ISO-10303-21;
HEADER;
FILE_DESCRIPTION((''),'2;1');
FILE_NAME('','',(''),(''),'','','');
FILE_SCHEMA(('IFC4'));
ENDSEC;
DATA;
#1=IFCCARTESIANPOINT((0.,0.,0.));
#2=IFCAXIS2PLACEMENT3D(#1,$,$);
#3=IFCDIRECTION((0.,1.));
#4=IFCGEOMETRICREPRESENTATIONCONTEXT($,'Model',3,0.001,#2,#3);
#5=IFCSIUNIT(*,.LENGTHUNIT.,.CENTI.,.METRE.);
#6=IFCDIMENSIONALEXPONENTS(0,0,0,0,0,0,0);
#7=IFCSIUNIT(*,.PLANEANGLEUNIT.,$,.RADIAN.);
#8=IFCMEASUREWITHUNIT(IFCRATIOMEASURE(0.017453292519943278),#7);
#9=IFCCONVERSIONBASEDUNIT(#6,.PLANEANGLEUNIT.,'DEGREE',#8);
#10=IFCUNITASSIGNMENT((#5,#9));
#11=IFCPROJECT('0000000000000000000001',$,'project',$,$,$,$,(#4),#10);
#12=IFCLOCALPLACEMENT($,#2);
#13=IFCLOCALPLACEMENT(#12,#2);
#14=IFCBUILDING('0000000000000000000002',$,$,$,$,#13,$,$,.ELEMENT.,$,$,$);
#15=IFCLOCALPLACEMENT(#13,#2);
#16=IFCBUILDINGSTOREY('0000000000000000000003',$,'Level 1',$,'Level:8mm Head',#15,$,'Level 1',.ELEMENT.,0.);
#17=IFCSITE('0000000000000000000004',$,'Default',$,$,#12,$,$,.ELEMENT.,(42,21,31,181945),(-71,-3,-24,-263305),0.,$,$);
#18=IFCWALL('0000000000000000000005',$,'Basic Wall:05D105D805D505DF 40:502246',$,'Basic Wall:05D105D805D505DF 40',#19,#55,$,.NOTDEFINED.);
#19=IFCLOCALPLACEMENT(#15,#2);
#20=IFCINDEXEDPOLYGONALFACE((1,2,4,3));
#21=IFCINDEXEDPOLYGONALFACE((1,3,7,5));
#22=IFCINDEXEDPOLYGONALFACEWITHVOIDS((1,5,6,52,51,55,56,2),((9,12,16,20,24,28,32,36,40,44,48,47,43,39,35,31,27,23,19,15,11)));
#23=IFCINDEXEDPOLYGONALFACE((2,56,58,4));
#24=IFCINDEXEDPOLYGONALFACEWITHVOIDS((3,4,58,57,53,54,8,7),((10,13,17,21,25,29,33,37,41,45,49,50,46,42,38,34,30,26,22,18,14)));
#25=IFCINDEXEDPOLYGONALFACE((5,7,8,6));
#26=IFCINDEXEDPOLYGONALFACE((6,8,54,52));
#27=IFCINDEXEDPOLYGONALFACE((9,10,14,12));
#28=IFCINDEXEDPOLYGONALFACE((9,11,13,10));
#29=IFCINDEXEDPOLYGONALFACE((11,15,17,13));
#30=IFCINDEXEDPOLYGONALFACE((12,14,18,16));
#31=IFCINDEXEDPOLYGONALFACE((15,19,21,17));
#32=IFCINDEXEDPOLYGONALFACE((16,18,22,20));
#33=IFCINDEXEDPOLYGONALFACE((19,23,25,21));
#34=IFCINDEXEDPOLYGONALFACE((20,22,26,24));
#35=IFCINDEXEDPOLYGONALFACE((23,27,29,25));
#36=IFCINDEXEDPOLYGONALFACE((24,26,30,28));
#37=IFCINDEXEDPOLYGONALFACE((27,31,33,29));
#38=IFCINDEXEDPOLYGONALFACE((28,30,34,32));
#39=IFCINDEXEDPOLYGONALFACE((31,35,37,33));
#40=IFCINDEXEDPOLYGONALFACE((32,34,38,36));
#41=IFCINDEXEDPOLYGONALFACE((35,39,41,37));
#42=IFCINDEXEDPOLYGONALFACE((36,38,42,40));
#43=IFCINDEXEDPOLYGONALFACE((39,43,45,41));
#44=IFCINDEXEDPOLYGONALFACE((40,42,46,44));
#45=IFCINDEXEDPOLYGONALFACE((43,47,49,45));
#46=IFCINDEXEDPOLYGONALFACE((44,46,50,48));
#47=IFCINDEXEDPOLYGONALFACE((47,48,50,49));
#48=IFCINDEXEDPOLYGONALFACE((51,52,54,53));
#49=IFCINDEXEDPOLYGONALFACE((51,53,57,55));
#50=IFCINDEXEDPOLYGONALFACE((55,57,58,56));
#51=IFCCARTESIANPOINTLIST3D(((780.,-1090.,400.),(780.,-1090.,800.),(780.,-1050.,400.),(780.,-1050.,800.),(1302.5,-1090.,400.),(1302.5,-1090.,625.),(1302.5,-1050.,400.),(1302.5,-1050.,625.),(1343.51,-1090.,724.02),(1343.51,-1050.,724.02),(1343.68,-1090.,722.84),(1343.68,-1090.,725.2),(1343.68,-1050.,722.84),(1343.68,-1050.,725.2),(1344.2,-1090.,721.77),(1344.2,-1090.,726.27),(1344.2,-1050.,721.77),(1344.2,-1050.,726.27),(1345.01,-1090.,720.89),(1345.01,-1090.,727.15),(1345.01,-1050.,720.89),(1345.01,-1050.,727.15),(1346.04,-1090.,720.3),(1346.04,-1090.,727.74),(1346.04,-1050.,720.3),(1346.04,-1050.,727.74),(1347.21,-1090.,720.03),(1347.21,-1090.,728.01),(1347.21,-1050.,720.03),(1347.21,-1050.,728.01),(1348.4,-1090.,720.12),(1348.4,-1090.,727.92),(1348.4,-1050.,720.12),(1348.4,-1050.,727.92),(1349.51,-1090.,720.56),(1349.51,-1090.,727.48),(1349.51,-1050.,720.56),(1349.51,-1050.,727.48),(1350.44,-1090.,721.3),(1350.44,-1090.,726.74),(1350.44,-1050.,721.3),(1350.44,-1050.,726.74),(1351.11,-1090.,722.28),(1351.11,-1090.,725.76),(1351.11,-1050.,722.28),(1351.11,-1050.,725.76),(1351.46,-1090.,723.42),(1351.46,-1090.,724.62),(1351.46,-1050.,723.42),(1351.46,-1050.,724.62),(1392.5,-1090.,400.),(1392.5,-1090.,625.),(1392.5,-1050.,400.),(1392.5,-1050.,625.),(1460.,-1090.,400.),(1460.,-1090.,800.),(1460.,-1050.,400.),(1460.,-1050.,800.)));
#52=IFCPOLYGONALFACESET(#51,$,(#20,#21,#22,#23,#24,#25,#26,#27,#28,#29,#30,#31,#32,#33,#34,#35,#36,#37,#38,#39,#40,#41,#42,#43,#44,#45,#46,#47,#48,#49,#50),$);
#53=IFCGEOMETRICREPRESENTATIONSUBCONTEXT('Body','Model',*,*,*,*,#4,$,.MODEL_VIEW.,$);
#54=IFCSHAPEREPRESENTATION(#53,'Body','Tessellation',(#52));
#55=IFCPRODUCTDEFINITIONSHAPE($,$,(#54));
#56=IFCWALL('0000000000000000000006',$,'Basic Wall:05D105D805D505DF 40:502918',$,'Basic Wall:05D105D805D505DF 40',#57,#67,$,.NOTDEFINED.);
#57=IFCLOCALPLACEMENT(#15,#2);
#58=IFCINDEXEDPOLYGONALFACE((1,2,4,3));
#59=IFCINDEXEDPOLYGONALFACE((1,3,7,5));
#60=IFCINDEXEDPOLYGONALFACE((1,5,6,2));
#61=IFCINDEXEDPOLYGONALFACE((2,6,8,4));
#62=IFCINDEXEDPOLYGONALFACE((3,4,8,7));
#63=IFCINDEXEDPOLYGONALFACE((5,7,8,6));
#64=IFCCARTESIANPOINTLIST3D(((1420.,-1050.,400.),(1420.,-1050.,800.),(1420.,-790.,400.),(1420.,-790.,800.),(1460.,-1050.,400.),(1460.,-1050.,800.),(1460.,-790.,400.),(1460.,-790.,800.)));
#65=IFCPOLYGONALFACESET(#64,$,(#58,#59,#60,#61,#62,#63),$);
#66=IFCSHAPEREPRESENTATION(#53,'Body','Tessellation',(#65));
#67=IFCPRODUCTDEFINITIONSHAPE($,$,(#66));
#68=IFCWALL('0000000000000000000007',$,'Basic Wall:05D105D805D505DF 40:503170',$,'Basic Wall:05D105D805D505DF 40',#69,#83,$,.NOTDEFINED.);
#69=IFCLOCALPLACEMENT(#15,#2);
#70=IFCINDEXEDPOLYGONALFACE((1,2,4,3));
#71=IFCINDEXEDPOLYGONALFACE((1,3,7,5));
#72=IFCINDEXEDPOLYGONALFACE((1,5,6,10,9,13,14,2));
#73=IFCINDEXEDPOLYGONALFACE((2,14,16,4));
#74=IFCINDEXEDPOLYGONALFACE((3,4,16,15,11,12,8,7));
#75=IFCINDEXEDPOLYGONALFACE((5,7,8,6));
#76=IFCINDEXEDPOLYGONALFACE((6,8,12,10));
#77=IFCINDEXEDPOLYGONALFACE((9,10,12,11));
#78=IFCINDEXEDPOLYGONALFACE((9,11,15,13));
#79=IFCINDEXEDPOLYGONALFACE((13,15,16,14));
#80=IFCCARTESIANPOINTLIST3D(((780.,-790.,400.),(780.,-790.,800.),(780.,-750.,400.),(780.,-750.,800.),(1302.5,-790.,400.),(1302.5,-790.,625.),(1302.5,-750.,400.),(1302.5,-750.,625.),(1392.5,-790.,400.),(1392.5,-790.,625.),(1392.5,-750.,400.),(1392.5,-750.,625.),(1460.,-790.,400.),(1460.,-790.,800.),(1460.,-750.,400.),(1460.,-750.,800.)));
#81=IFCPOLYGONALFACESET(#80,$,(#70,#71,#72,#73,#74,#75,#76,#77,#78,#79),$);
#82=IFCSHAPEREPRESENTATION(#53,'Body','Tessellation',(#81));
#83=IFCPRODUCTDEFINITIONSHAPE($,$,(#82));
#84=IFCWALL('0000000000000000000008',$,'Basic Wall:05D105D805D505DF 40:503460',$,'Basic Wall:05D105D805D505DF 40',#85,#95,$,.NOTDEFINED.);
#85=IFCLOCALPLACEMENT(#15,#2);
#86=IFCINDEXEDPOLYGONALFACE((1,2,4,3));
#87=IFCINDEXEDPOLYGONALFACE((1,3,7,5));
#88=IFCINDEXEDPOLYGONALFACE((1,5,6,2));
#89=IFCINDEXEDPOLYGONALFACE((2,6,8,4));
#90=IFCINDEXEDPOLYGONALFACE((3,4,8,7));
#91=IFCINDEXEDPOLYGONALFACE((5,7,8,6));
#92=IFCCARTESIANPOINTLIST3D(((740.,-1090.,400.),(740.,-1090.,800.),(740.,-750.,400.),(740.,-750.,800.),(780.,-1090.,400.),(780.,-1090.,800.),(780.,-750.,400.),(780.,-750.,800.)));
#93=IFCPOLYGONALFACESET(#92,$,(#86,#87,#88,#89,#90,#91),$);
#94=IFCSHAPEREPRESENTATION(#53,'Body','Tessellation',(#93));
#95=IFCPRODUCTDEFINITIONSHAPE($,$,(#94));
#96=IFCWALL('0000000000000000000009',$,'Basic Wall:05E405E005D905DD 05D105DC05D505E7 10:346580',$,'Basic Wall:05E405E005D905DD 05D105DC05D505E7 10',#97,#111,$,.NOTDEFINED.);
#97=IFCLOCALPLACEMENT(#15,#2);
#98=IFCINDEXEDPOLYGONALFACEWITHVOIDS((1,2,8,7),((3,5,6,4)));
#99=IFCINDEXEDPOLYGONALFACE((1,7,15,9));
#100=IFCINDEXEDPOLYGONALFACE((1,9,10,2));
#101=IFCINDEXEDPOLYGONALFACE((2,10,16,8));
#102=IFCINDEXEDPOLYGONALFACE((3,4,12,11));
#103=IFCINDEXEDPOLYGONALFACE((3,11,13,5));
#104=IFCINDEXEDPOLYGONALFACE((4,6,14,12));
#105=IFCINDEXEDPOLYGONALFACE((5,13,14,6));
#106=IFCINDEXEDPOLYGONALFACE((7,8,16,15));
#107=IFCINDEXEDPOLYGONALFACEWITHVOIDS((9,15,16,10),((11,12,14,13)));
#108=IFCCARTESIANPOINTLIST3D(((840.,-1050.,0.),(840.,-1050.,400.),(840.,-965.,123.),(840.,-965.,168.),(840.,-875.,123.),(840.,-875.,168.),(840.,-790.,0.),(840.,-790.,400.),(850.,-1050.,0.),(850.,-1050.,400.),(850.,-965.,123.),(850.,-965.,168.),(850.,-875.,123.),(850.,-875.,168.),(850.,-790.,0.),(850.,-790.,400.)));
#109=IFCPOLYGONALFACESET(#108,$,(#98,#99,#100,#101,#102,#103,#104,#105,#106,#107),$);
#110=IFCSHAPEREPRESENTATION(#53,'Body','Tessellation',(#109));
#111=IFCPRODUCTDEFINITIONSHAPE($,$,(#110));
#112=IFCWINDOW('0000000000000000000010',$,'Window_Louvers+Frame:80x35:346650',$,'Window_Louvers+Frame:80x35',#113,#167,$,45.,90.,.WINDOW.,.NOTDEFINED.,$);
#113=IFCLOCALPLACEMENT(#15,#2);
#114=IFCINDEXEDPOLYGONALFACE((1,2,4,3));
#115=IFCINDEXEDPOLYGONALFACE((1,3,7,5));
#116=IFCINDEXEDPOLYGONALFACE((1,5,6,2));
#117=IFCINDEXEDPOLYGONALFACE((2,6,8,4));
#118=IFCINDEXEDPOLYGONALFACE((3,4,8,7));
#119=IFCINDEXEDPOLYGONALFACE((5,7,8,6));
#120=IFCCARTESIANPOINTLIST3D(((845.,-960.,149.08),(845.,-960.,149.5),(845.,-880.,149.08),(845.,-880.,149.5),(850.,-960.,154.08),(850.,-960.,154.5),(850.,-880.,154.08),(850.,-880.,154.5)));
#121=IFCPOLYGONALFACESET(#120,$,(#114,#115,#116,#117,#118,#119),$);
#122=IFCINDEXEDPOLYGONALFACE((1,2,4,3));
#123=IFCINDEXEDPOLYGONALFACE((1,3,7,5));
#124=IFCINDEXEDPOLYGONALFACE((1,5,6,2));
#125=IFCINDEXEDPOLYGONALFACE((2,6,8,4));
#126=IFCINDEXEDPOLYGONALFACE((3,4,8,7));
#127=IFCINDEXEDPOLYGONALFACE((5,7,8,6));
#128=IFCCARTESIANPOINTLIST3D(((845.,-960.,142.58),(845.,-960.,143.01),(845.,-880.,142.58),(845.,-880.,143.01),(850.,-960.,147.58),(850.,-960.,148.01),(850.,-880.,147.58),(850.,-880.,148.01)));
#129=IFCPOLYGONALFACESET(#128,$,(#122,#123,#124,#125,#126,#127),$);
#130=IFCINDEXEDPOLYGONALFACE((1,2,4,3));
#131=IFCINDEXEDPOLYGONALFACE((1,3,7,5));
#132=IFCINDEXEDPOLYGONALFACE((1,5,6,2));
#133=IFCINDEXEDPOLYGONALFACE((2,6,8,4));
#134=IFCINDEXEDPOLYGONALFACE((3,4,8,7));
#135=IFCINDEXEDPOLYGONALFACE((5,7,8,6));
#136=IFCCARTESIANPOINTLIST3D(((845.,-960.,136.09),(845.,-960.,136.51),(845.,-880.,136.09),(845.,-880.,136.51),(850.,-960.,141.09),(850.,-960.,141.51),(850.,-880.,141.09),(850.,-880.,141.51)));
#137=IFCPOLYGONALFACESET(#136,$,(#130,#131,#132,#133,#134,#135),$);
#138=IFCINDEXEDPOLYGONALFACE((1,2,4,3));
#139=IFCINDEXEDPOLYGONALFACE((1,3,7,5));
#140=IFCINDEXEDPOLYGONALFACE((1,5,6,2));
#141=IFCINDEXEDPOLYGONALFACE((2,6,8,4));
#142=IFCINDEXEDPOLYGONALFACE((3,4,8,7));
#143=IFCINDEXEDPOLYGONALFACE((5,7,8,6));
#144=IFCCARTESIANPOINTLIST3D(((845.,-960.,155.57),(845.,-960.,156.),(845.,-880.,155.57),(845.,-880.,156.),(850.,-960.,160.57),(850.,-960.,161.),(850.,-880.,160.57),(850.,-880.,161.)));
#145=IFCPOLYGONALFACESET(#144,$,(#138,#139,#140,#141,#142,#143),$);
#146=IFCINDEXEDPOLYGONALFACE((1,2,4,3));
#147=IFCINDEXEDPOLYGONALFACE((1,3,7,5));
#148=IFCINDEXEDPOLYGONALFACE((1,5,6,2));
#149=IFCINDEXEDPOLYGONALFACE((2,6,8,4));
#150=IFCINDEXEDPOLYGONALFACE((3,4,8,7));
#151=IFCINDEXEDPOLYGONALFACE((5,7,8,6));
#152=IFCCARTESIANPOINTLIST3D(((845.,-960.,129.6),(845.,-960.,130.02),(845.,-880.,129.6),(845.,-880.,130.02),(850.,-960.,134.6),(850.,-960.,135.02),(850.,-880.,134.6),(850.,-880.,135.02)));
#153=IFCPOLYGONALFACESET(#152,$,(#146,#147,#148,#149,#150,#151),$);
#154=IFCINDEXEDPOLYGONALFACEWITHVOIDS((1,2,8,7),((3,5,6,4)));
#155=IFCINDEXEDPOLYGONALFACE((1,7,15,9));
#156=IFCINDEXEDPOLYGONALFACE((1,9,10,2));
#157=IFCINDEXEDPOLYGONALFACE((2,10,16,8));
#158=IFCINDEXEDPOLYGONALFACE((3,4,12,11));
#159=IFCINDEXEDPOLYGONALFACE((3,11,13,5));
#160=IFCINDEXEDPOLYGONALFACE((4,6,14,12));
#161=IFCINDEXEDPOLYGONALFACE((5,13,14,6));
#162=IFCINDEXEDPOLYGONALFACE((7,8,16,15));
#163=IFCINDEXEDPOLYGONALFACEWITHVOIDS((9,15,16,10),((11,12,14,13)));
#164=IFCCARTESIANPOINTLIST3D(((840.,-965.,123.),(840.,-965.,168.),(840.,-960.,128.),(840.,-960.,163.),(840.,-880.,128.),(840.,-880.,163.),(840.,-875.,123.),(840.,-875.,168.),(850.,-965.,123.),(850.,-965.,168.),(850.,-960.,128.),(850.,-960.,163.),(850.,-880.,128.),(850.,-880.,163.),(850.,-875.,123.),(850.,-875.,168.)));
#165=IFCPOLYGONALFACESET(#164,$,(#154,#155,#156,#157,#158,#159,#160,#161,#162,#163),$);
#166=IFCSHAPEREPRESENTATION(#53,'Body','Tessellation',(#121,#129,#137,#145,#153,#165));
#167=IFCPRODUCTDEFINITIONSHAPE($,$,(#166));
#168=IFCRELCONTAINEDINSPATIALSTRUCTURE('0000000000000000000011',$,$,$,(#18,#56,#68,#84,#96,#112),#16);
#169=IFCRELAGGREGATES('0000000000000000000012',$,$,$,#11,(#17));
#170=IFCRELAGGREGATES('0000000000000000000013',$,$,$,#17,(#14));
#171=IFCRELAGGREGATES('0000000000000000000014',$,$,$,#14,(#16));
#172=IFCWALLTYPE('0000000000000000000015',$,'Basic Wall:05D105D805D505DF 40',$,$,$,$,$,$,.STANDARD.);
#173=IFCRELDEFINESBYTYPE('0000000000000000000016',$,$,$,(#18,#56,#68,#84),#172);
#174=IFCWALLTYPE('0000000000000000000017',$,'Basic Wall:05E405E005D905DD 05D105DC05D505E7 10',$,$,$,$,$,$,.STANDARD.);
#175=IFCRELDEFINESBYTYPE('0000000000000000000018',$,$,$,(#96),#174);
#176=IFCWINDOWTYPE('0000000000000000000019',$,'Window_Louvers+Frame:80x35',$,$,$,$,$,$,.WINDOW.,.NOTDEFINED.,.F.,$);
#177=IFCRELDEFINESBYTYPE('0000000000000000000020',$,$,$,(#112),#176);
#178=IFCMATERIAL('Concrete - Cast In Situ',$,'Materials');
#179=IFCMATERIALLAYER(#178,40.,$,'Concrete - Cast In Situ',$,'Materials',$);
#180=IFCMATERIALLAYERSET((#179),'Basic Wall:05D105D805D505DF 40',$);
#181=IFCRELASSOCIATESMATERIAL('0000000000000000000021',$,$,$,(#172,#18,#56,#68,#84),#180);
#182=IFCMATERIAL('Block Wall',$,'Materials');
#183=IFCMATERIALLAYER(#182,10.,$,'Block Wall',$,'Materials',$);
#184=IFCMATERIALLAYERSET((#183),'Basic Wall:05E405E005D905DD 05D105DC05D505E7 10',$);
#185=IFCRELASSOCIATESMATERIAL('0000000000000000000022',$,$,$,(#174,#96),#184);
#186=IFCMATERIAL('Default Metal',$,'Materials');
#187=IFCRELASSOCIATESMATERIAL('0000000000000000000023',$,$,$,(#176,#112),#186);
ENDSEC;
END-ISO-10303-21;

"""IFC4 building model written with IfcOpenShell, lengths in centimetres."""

from ifc_helpers import new_model, entity, si_unit, converted_unit, direction, frame, frame_2d, origin, origin_2d_with_axis, place, context, subcontext, project, spatial, polyline, rectangle, circle, outline, extrude, source, transform, mapped, material, layer, layer_set, layer_usage, type_object, type_shapes, element, fill, save


model = new_model("IFC4")

# Units and contexts
model_context = context("Model", 3, precision=0.001, world=origin(), true_north=direction((0.0, 1.0)))
body_context = subcontext(model_context, "Body", "Model", "MODEL_VIEW")
ifc_project = project(units=[si_unit("LENGTHUNIT", "METRE", prefix="CENTI"), converted_unit("PLANEANGLEUNIT", "DEGREE", entity("IfcRatioMeasure", 0.017453292519943278), si_unit("PLANEANGLEUNIT", "RADIAN"), dimensions=[0, 0, 0, 0, 0, 0, 0])], contexts=[model_context])

# Site, building, storey
site_placement = place(None, origin())
site = spatial("IfcSite", under=ifc_project, at=site_placement, Name="Default", CompositionType="ELEMENT", RefLatitude=(42, 21, 31, 181945), RefLongitude=(-71, -3, -24, -263305), RefElevation=0.0)
building_placement = place(site_placement, origin())
building = spatial("IfcBuilding", under=site, at=building_placement, CompositionType="ELEMENT")
storey_placement = place(building_placement, origin())
storey = spatial("IfcBuildingStorey", under=building, at=storey_placement, Name="Level 1", ObjectType="Level:8mm Head", LongName="Level 1", CompositionType="ELEMENT", Elevation=0.0)

# Shared definitions
ifc_material_1 = material(Name="Concrete - Cast In Situ", Category="Materials")
ifc_layer_1 = layer(ifc_material_1, 40.0, Name="Concrete - Cast In Situ", Category="Materials")
ifc_layer_set_1 = layer_set([ifc_layer_1], Name="Basic Wall:05D105D805D505DF 40")
wall_type_1 = type_object("IfcWallType", Name="Basic Wall:05D105D805D505DF 40", PredefinedType="STANDARD", material=ifc_layer_set_1)

# Wall, openings
ifc_layer_usage_1 = layer_usage(ifc_layer_set_1, "AXIS2", "POSITIVE", -20.0)
wall_1_placement = place(storey_placement, frame((780.0, -1070.0, 400.0)))
wall_1 = element("IfcWall", 1, at=wall_1_placement, inside=storey, type_object=wall_type_1, material=ifc_layer_usage_1, Name="Basic Wall:05D105D805D505DF 40:502246", ObjectType="Basic Wall:05D105D805D505DF 40", PredefinedType="NOTDEFINED", context=body_context, shape_type="SweptSolid", body=[
    extrude(rectangle(XDim=680.0, YDim=40.0, at=frame_2d((340.0, 0.0), x_axis=(-1.0, 0.0))), origin(), (0.0, 0.0, 1.0), 400.0),
])
opening_1_placement = place(wall_1_placement, frame((522.5, -172.4, 0.0)))
element("IfcOpeningElement", 2, at=opening_1_placement, cuts=wall_1, PredefinedType="OPENING", context=body_context, shape_type="SweptSolid", body=[
    extrude(rectangle(XDim=225.0, YDim=90.0, at=frame_2d((0.0, 0.0), x_axis=(0.0, 1.0))), frame((45.0, 0.0, 112.5), z_axis=(0.0, 1.0, 0.0), x_axis=(1.0, 0.0, 0.0)), (0.0, 0.0, 1.0), 304.8),
])
opening_2_placement = place(wall_1_placement, origin())
element("IfcOpeningElement", 3, at=opening_2_placement, cuts=wall_1, PredefinedType="OPENING", context=body_context, shape_type="SweptSolid", body=[
    extrude(circle(Radius=4.0, at=origin_2d_with_axis()), frame((567.51, 20.0, 324.02), z_axis=(0.0, -1.0, 0.0), x_axis=(-1.0, 0.0, 0.0)), (0.0, 0.0, 1.0), 40.0),
])

# Wall
ifc_layer_usage_2 = layer_usage(ifc_layer_set_1, "AXIS2", "NEGATIVE", 20.0)
wall_2_placement = place(storey_placement, frame((1440.0, -1050.0, 400.0), z_axis=(0.0, 0.0, 1.0), x_axis=(0.0, 1.0, 0.0)))
element("IfcWall", 4, at=wall_2_placement, inside=storey, type_object=wall_type_1, material=ifc_layer_usage_2, Name="Basic Wall:05D105D805D505DF 40:502918", ObjectType="Basic Wall:05D105D805D505DF 40", PredefinedType="NOTDEFINED", context=body_context, shape_type="SweptSolid", body=[
    extrude(rectangle(XDim=260.0, YDim=40.0, at=frame_2d((130.0, 0.0), x_axis=(-1.0, 0.0))), origin(), (0.0, 0.0, 1.0), 400.0),
])

# Wall, opening
ifc_layer_usage_3 = layer_usage(ifc_layer_set_1, "AXIS2", "NEGATIVE", 20.0)
wall_3_placement = place(storey_placement, frame((780.0, -770.0, 400.0)))
wall_3 = element("IfcWall", 5, at=wall_3_placement, inside=storey, type_object=wall_type_1, material=ifc_layer_usage_3, Name="Basic Wall:05D105D805D505DF 40:503170", ObjectType="Basic Wall:05D105D805D505DF 40", PredefinedType="NOTDEFINED", context=body_context, shape_type="SweptSolid", body=[
    extrude(rectangle(XDim=680.0, YDim=40.0, at=frame_2d((340.0, 0.0), x_axis=(-1.0, 0.0))), origin(), (0.0, 0.0, 1.0), 400.0),
])
opening_3_placement = place(wall_3_placement, frame((522.5, -132.4, 0.0)))
element("IfcOpeningElement", 6, at=opening_3_placement, cuts=wall_3, PredefinedType="OPENING", context=body_context, shape_type="SweptSolid", body=[
    extrude(rectangle(XDim=225.0, YDim=90.0, at=frame_2d((0.0, 0.0), x_axis=(0.0, 1.0))), frame((45.0, 0.0, 112.5), z_axis=(0.0, 1.0, 0.0), x_axis=(1.0, 0.0, 0.0)), (0.0, 0.0, 1.0), 304.8),
])

# Wall
ifc_layer_usage_4 = layer_usage(ifc_layer_set_1, "AXIS2", "NEGATIVE", 20.0)
wall_4_placement = place(storey_placement, frame((760.0, -1090.0, 400.0), z_axis=(0.0, 0.0, 1.0), x_axis=(0.0, 1.0, 0.0)))
element("IfcWall", 7, at=wall_4_placement, inside=storey, type_object=wall_type_1, material=ifc_layer_usage_4, Name="Basic Wall:05D105D805D505DF 40:503460", ObjectType="Basic Wall:05D105D805D505DF 40", PredefinedType="NOTDEFINED", context=body_context, shape_type="SweptSolid", body=[
    extrude(rectangle(XDim=340.0, YDim=40.0, at=frame_2d((170.0, 0.0), x_axis=(-1.0, 0.0))), origin(), (0.0, 0.0, 1.0), 400.0),
])

# Wall, opening, window
ifc_material_2 = material(Name="Block Wall", Category="Materials")
ifc_layer_2 = layer(ifc_material_2, 10.0, Name="Block Wall", Category="Materials")
ifc_layer_set_2 = layer_set([ifc_layer_2], Name="Basic Wall:05E405E005D905DD 05D105DC05D505E7 10")
ifc_layer_usage_5 = layer_usage(ifc_layer_set_2, "AXIS2", "NEGATIVE", 5.0)
wall_type_2 = type_object("IfcWallType", Name="Basic Wall:05E405E005D905DD 05D105DC05D505E7 10", PredefinedType="STANDARD", material=ifc_layer_set_2)
wall_5_placement = place(storey_placement, frame((845.0, -790.0, 0.0), z_axis=(0.0, 0.0, 1.0), x_axis=(0.0, -1.0, 0.0)))
wall_5 = element("IfcWall", 8, at=wall_5_placement, inside=storey, type_object=wall_type_2, material=ifc_layer_usage_5, Name="Basic Wall:05E405E005D905DD 05D105DC05D505E7 10:346580", ObjectType="Basic Wall:05E405E005D905DD 05D105DC05D505E7 10", PredefinedType="NOTDEFINED", context=body_context, shape_type="SweptSolid", body=[
    extrude(rectangle(XDim=260.0, YDim=10.0, at=frame_2d((130.0, 0.0), x_axis=(-1.0, 0.0))), origin(), (0.0, 0.0, 1.0), 400.0),
])
opening_4_placement = place(wall_5_placement, frame((85.0, -5.0, 123.0)))
opening_4 = element("IfcOpeningElement", 9, at=opening_4_placement, cuts=wall_5, PredefinedType="OPENING", context=body_context, shape_type="SweptSolid", body=[
    extrude(rectangle(XDim=45.0, YDim=90.0, at=frame_2d((22.5, 45.0), x_axis=(-1.0, 0.0))), frame((0.0, 0.0, 0.0), z_axis=(0.0, 1.0, 0.0), x_axis=(0.0, 0.0, 1.0)), (0.0, 0.0, 1.0), 10.0),
])
ifc_material_3 = material(Name="Default Metal", Category="Materials")
window_type = type_object("IfcWindowType", Name="Window_Louvers+Frame:80x35", ParameterTakesPrecedence=False, PartitioningType="NOTDEFINED", PredefinedType="WINDOW", material=ifc_material_3)
shared_shape = source(origin(), body_context, "Body", "SweptSolid", [
    extrude(outline(polyline([(-3.39, -0.15), (3.69, -0.15), (3.39, 0.15), (-3.69, 0.15), (-3.39, -0.15)])), frame((5.0, 2.5, 28.79), z_axis=(1.0, 0.0, 0.0), x_axis=(0.0, -0.707107, 0.707107)), (0.0, 0.0, 1.0), 80.0),
    extrude(outline(polyline([(-3.39, -0.15), (3.69, -0.15), (3.39, 0.15), (-3.69, 0.15), (-3.39, -0.15)])), frame((5.0, 2.5, 22.3), z_axis=(1.0, 0.0, 0.0), x_axis=(0.0, -0.707107, 0.707107)), (0.0, 0.0, 1.0), 80.0),
    extrude(outline(polyline([(-3.39, -0.15), (3.69, -0.15), (3.39, 0.15), (-3.69, 0.15), (-3.39, -0.15)])), frame((5.0, 2.5, 15.8), z_axis=(1.0, 0.0, 0.0), x_axis=(0.0, -0.707107, 0.707107)), (0.0, 0.0, 1.0), 80.0),
    extrude(outline(polyline([(-3.39, -0.15), (3.69, -0.15), (3.39, 0.15), (-3.69, 0.15), (-3.39, -0.15)])), frame((5.0, 2.5, 35.28), z_axis=(1.0, 0.0, 0.0), x_axis=(0.0, -0.707107, 0.707107)), (0.0, 0.0, 1.0), 80.0),
    extrude(outline(polyline([(-3.39, -0.15), (3.69, -0.15), (3.39, 0.15), (-3.69, 0.15), (-3.39, -0.15)])), frame((5.0, 2.5, 9.31), z_axis=(1.0, 0.0, 0.0), x_axis=(0.0, -0.707107, 0.707107)), (0.0, 0.0, 1.0), 80.0),
    extrude(outline(polyline([(-22.5, -45.0), (22.5, -45.0), (22.5, 45.0), (-22.5, 45.0), (-22.5, -45.0)]), holes=[polyline([(17.5, -40.0), (-17.5, -40.0), (-17.5, 40.0), (17.5, 40.0), (17.5, -40.0)])]), frame((45.0, 0.0, 22.5), z_axis=(0.0, 1.0, 0.0), x_axis=(0.0, 0.0, 1.0)), (0.0, 0.0, 1.0), 10.0),
])
type_shapes(window_type, [shared_shape])
window_placement = place(opening_4_placement, frame((90.0, 10.0, 0.0), z_axis=(0.0, 0.0, 1.0), x_axis=(-1.0, 0.0, 0.0)))
window = element("IfcWindow", 10, at=window_placement, inside=storey, type_object=window_type, material=ifc_material_3, Name="Window_Louvers+Frame:80x35:346650", ObjectType="Window_Louvers+Frame:80x35", OverallHeight=45.0, OverallWidth=90.0, PartitioningType="NOTDEFINED", PredefinedType="WINDOW", context=body_context, shape_type="MappedRepresentation", body=[
    mapped(shared_shape, transform((0.0, 0.0, 0.0), scale=1.0)),
])
fill(opening_4, window)

save(model, "model.ifc")
